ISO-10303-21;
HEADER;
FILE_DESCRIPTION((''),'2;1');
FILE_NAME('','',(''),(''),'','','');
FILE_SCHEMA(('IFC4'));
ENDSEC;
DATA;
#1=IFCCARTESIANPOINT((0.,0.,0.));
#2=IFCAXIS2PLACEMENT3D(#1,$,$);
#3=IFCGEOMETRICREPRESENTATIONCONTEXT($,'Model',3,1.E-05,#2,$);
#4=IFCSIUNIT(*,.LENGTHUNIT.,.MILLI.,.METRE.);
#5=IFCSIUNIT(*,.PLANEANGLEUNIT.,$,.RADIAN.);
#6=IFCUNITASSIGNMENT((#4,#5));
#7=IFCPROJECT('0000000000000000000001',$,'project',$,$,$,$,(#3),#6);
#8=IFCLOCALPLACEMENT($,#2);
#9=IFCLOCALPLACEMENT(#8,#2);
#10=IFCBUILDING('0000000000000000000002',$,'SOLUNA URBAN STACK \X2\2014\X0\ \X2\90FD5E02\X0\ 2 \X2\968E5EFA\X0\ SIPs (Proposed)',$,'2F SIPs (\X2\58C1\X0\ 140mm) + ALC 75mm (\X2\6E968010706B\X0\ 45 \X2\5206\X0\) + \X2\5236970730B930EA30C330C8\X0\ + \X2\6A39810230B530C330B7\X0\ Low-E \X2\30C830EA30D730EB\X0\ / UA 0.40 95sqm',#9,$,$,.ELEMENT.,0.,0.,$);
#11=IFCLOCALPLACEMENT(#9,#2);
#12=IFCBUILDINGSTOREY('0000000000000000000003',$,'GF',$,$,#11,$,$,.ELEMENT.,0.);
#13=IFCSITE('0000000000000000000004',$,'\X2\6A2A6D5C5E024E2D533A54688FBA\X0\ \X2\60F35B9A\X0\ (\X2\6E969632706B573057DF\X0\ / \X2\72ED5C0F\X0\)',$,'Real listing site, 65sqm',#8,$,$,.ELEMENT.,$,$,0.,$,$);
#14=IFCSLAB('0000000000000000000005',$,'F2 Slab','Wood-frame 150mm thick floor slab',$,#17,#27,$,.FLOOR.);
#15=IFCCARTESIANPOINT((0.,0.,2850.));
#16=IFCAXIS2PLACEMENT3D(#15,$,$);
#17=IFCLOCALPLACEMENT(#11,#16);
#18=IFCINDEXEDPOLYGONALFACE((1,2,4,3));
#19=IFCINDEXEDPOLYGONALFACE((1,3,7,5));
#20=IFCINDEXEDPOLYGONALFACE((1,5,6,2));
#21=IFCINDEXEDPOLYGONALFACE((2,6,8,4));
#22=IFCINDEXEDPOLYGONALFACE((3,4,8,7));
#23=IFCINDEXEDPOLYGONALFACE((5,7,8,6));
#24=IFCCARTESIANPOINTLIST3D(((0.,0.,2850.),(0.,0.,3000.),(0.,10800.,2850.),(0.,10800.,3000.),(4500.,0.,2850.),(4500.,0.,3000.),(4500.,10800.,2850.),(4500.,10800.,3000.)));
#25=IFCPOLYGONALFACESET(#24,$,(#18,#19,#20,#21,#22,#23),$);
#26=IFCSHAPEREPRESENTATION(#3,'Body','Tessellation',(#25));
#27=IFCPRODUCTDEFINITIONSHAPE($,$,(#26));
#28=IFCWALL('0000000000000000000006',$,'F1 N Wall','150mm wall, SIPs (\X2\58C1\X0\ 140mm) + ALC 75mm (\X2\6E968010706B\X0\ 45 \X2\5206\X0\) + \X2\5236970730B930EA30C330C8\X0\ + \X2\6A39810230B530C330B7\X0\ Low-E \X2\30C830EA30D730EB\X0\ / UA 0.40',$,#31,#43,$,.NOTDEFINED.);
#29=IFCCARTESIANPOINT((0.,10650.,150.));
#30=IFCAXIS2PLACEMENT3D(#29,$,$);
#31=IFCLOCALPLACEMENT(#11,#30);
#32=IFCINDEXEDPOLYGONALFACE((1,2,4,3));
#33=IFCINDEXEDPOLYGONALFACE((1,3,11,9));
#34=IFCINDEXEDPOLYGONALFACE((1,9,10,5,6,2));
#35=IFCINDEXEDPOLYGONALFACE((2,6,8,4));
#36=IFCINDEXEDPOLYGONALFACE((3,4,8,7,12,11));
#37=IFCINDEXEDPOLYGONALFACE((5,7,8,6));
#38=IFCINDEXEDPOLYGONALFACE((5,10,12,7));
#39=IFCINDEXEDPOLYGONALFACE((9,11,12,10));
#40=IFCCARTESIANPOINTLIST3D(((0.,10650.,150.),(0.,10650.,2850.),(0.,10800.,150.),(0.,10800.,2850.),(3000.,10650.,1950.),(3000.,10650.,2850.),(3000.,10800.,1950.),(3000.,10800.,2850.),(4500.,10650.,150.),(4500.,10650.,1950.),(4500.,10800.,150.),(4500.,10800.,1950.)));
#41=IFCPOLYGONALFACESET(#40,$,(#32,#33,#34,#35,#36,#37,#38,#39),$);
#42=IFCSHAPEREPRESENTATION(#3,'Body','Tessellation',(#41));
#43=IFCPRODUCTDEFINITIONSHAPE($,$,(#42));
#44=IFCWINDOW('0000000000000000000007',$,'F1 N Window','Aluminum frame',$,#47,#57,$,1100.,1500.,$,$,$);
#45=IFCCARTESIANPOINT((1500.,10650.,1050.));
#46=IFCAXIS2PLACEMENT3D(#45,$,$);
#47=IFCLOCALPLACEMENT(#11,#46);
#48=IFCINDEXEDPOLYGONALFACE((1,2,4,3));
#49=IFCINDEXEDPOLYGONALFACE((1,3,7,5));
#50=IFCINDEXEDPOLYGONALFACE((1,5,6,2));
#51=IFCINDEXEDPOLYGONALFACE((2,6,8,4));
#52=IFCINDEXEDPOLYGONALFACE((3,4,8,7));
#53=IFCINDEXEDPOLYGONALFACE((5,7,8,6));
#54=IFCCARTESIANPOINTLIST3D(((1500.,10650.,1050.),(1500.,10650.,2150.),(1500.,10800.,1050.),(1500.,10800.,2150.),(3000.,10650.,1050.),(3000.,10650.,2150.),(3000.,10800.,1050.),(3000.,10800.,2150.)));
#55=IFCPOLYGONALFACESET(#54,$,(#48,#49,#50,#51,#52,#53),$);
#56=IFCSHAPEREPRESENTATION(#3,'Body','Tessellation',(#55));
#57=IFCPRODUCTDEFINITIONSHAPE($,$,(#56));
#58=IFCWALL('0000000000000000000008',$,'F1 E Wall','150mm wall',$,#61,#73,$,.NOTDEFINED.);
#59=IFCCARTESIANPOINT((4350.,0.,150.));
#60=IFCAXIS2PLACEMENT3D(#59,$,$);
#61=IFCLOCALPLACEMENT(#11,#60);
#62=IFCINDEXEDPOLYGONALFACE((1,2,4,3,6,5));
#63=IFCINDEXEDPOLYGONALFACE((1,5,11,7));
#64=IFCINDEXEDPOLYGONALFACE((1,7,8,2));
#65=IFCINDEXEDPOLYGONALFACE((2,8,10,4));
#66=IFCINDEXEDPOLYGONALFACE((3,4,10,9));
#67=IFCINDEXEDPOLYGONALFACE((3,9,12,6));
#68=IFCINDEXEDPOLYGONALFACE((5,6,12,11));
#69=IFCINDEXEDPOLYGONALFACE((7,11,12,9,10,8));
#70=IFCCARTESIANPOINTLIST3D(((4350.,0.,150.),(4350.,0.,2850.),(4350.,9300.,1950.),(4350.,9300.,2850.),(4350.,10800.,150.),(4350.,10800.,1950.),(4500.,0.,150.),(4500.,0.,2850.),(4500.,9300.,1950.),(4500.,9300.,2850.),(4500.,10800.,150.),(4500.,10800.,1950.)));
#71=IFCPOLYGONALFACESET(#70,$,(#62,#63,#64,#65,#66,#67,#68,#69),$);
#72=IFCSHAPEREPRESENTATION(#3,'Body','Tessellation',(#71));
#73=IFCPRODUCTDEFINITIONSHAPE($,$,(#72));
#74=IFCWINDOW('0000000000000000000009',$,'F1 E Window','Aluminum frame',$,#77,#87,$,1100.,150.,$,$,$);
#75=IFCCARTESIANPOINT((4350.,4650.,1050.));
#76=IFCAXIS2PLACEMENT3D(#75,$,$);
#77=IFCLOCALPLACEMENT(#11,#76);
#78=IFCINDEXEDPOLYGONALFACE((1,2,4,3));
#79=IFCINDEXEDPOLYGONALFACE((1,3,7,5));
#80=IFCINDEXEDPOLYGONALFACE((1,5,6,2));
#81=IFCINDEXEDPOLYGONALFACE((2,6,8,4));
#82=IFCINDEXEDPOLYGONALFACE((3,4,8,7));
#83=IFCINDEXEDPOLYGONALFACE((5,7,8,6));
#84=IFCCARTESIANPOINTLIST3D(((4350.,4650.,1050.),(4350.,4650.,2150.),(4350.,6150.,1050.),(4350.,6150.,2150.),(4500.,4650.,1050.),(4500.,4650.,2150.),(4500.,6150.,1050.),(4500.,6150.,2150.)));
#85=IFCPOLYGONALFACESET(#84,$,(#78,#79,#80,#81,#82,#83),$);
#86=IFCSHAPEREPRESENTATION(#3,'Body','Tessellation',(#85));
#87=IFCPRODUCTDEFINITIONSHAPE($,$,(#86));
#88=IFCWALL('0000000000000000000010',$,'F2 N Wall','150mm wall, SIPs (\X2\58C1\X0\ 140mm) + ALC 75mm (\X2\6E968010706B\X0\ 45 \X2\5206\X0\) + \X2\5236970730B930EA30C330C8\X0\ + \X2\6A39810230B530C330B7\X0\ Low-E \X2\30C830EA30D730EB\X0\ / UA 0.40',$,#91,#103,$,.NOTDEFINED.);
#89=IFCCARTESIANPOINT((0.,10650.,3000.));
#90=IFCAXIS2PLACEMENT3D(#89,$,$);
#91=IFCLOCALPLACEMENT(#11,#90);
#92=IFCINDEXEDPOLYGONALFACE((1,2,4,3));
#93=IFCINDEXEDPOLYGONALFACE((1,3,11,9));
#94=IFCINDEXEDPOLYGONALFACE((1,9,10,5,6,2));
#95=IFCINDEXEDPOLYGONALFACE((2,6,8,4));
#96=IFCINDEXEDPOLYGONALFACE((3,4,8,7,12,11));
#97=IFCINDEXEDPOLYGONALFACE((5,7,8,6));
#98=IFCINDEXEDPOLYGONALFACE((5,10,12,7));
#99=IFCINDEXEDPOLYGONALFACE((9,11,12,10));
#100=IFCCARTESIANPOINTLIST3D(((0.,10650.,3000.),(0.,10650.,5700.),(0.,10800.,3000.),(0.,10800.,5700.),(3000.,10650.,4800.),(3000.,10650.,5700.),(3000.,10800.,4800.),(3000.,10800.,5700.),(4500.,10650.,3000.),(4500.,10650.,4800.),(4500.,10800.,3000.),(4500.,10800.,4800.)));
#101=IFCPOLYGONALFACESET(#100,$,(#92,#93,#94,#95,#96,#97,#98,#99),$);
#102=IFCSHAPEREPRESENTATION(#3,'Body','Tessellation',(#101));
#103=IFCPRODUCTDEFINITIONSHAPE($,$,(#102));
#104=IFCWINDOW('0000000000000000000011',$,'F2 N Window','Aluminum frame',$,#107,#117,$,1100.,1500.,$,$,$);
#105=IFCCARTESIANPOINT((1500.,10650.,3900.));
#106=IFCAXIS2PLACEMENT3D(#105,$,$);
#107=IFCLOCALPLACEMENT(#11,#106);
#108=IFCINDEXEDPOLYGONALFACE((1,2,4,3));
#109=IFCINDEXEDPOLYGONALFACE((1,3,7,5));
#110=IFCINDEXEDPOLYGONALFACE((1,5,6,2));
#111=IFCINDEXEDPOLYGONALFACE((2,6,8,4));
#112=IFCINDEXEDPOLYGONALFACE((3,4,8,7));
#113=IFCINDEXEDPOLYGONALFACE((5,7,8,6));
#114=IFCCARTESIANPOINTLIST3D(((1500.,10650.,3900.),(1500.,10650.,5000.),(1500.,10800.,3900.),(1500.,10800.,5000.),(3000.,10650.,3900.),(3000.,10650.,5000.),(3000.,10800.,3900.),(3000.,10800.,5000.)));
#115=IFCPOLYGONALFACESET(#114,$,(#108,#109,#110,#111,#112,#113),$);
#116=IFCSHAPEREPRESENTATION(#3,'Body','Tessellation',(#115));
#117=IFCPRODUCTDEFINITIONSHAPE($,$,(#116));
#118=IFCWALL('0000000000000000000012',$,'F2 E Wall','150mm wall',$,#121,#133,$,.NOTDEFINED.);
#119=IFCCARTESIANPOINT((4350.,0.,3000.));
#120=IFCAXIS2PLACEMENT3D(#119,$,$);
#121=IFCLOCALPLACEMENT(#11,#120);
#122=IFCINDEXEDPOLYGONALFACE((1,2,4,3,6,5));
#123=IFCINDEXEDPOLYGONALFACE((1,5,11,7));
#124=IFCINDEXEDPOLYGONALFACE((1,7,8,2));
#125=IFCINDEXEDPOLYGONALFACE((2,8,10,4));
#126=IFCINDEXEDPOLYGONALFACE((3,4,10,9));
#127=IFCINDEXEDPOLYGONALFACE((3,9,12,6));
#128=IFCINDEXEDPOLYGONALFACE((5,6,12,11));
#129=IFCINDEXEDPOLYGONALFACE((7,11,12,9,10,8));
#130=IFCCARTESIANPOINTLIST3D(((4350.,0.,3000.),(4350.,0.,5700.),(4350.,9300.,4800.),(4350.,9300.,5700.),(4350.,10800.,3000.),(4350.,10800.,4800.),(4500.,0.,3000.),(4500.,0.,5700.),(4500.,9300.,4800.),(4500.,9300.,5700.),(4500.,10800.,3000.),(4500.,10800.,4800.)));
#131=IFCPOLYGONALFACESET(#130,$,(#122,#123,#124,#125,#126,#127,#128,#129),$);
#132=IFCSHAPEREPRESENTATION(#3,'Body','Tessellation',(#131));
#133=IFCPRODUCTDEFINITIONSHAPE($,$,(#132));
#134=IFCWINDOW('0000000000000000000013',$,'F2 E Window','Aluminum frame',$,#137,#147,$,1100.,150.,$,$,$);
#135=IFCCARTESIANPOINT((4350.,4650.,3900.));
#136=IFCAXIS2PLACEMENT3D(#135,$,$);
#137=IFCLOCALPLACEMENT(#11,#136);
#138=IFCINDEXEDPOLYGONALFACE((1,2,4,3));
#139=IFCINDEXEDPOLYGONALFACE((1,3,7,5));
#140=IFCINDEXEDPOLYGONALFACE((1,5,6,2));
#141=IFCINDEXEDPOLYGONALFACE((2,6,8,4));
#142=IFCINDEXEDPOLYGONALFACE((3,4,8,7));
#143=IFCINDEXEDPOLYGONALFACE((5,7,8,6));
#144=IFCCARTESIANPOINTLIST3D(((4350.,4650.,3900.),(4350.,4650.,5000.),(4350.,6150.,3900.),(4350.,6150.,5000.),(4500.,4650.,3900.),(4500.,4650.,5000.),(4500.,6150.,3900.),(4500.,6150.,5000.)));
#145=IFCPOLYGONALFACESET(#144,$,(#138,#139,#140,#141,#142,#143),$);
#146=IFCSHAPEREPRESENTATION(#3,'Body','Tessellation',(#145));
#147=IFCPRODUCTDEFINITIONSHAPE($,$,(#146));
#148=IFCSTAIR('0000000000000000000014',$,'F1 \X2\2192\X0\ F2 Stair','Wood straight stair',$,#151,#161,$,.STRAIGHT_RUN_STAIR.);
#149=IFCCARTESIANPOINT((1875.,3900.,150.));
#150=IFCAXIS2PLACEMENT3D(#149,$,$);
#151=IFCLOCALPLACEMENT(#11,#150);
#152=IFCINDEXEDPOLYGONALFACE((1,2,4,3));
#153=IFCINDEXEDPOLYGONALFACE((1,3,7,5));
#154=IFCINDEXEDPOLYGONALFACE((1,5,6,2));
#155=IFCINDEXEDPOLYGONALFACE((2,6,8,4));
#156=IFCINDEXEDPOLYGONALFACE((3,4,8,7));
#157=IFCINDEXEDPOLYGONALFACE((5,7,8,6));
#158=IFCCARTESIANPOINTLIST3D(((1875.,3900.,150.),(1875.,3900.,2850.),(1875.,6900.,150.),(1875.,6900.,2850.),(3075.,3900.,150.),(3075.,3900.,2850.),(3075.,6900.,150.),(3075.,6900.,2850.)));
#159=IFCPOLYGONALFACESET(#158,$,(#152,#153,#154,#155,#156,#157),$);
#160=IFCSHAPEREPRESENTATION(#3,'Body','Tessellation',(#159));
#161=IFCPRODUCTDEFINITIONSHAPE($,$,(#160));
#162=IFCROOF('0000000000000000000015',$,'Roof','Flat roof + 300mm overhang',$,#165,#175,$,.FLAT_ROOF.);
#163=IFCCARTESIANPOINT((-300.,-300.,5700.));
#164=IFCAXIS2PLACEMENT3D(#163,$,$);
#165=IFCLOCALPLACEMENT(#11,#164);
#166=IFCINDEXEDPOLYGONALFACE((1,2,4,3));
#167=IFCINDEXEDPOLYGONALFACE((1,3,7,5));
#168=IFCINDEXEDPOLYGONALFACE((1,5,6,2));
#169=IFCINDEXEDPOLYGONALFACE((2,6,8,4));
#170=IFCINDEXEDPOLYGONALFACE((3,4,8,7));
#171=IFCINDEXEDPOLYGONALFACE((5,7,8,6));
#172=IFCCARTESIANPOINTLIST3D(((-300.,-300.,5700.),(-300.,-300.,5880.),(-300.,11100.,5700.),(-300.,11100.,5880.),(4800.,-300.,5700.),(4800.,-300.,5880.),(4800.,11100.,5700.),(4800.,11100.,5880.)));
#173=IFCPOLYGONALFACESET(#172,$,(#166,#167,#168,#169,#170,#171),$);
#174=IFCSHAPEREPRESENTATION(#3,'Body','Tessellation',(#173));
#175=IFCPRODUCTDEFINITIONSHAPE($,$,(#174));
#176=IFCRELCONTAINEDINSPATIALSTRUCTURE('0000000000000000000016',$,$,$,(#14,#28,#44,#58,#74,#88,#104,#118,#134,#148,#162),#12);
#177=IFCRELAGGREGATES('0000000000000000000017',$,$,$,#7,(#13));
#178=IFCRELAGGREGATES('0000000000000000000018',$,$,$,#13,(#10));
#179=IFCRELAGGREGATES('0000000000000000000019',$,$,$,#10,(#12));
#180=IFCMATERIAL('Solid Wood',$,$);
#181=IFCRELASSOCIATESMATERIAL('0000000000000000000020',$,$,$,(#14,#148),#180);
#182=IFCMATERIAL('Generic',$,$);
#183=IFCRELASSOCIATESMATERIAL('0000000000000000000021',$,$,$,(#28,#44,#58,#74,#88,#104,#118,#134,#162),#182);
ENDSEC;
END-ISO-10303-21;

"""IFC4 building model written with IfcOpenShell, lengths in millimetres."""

from ifc_helpers import new_model, si_unit, frame, frame_2d, origin, place, context, project, spatial, rectangle, extrude, material, element, fill, save


model = new_model("IFC4")

# Units and contexts
model_context = context("Model", 3, precision=1e-05, world=origin())
ifc_project = project(units=[si_unit("LENGTHUNIT", "METRE", prefix="MILLI"), si_unit("PLANEANGLEUNIT", "RADIAN")], contexts=[model_context])

# Site, building, storey
site_placement = place(None, origin())
site = spatial("IfcSite", under=ifc_project, at=site_placement, Name="横浜市中区周辺 想定 (準防火地域 / 狭小)", ObjectType="Real listing site, 65sqm", CompositionType="ELEMENT", RefElevation=0.0)
building_placement = place(site_placement, origin())
building = spatial("IfcBuilding", under=site, at=building_placement, Name="SOLUNA URBAN STACK — 都市 2 階建 SIPs (Proposed)", ObjectType="2F SIPs (壁 140mm) + ALC 75mm (準耐火 45 分) + 制震スリット + 樹脂サッシ Low-E トリプル / UA 0.40 95sqm", CompositionType="ELEMENT", ElevationOfRefHeight=0.0, ElevationOfTerrain=0.0)
storey_placement = place(building_placement, origin())
storey = spatial("IfcBuildingStorey", under=building, at=storey_placement, Name="GF", CompositionType="ELEMENT", Elevation=0.0)

# Slab
ifc_material_1 = material(Name="Solid Wood")
slab_1_placement = place(storey_placement, frame((0.0, 0.0, 2850.0)))
element("IfcSlab", 1, at=slab_1_placement, inside=storey, material=ifc_material_1, Name="F2 Slab", Description="Wood-frame 150mm thick floor slab", PredefinedType="FLOOR", context=model_context, shape_type="SweptSolid", body=[
    extrude(rectangle(XDim=4500.0, YDim=10800.0, at=frame_2d((2250.0, 5400.0))), frame((0.0, 0.0, 2850.0)), (0.0, 0.0, 1.0), 150.0),
])

# Wall, opening, window
ifc_material_2 = material(Name="Generic")
wall_1_placement = place(storey_placement, frame((0.0, 10650.0, 150.0)))
wall_1 = element("IfcWall", 2, at=wall_1_placement, inside=storey, material=ifc_material_2, Name="F1 N Wall", Description="150mm wall, SIPs (壁 140mm) + ALC 75mm (準耐火 45 分) + 制震スリット + 樹脂サッシ Low-E トリプル / UA 0.40", PredefinedType="NOTDEFINED", context=model_context, shape_type="SweptSolid", body=[
    extrude(rectangle(XDim=4500.0, YDim=150.0, at=frame_2d((2250.0, 75.0))), frame((0.0, 10650.0, 150.0)), (0.0, 0.0, 1.0), 2700.0),
])
opening_1_placement = place(storey_placement, frame((1500.0, 10650.0, 1050.0)))
opening_1 = element("IfcOpeningElement", 3, at=opening_1_placement, cuts=wall_1, PredefinedType="NOTDEFINED", context=model_context, shape_type="SweptSolid", body=[
    extrude(rectangle(XDim=1500.0, YDim=150.0, at=frame_2d((750.0, 75.0))), frame((1500.0, 10650.0, 1050.0)), (0.0, 0.0, 1.0), 1100.0),
])
window_1_placement = place(storey_placement, frame((1500.0, 10650.0, 1050.0)))
window_1 = element("IfcWindow", 4, at=window_1_placement, inside=storey, material=ifc_material_2, Name="F1 N Window", Description="Aluminum frame", OverallHeight=1100.0, OverallWidth=1500.0, context=model_context, shape_type="SweptSolid", body=[
    extrude(rectangle(XDim=1500.0, YDim=150.0, at=frame_2d((750.0, 75.0))), frame((1500.0, 10650.0, 1050.0)), (0.0, 0.0, 1.0), 1100.0),
])
fill(opening_1, window_1)

# Walls, openings, windows
wall_2_placement = place(storey_placement, frame((4350.0, 0.0, 150.0)))
wall_2 = element("IfcWall", 5, at=wall_2_placement, inside=storey, material=ifc_material_2, Name="F1 E Wall", Description="150mm wall", PredefinedType="NOTDEFINED", context=model_context, shape_type="SweptSolid", body=[
    extrude(rectangle(XDim=150.0, YDim=10800.0, at=frame_2d((75.0, 5400.0))), frame((4350.0, 0.0, 150.0)), (0.0, 0.0, 1.0), 2700.0),
])
opening_2_placement = place(storey_placement, frame((4350.0, 4650.0, 1050.0)))
opening_2 = element("IfcOpeningElement", 6, at=opening_2_placement, cuts=wall_2, PredefinedType="NOTDEFINED", context=model_context, shape_type="SweptSolid", body=[
    extrude(rectangle(XDim=150.0, YDim=1500.0, at=frame_2d((75.0, 750.0))), frame((4350.0, 4650.0, 1050.0)), (0.0, 0.0, 1.0), 1100.0),
])
window_2_placement = place(storey_placement, frame((4350.0, 4650.0, 1050.0)))
window_2 = element("IfcWindow", 7, at=window_2_placement, inside=storey, material=ifc_material_2, Name="F1 E Window", Description="Aluminum frame", OverallHeight=1100.0, OverallWidth=150.0, context=model_context, shape_type="SweptSolid", body=[
    extrude(rectangle(XDim=150.0, YDim=1500.0, at=frame_2d((75.0, 750.0))), frame((4350.0, 4650.0, 1050.0)), (0.0, 0.0, 1.0), 1100.0),
])
fill(opening_2, window_2)
wall_3_placement = place(storey_placement, frame((0.0, 10650.0, 3000.0)))
wall_3 = element("IfcWall", 8, at=wall_3_placement, inside=storey, material=ifc_material_2, Name="F2 N Wall", Description="150mm wall, SIPs (壁 140mm) + ALC 75mm (準耐火 45 分) + 制震スリット + 樹脂サッシ Low-E トリプル / UA 0.40", PredefinedType="NOTDEFINED", context=model_context, shape_type="SweptSolid", body=[
    extrude(rectangle(XDim=4500.0, YDim=150.0, at=frame_2d((2250.0, 75.0))), frame((0.0, 10650.0, 3000.0)), (0.0, 0.0, 1.0), 2700.0),
])
opening_3_placement = place(storey_placement, frame((1500.0, 10650.0, 3900.0)))
opening_3 = element("IfcOpeningElement", 9, at=opening_3_placement, cuts=wall_3, PredefinedType="NOTDEFINED", context=model_context, shape_type="SweptSolid", body=[
    extrude(rectangle(XDim=1500.0, YDim=150.0, at=frame_2d((750.0, 75.0))), frame((1500.0, 10650.0, 3900.0)), (0.0, 0.0, 1.0), 1100.0),
])
window_3_placement = place(storey_placement, frame((1500.0, 10650.0, 3900.0)))
window_3 = element("IfcWindow", 10, at=window_3_placement, inside=storey, material=ifc_material_2, Name="F2 N Window", Description="Aluminum frame", OverallHeight=1100.0, OverallWidth=1500.0, context=model_context, shape_type="SweptSolid", body=[
    extrude(rectangle(XDim=1500.0, YDim=150.0, at=frame_2d((750.0, 75.0))), frame((1500.0, 10650.0, 3900.0)), (0.0, 0.0, 1.0), 1100.0),
])
fill(opening_3, window_3)
wall_4_placement = place(storey_placement, frame((4350.0, 0.0, 3000.0)))
wall_4 = element("IfcWall", 11, at=wall_4_placement, inside=storey, material=ifc_material_2, Name="F2 E Wall", Description="150mm wall", PredefinedType="NOTDEFINED", context=model_context, shape_type="SweptSolid", body=[
    extrude(rectangle(XDim=150.0, YDim=10800.0, at=frame_2d((75.0, 5400.0))), frame((4350.0, 0.0, 3000.0)), (0.0, 0.0, 1.0), 2700.0),
])
opening_4_placement = place(storey_placement, frame((4350.0, 4650.0, 3900.0)))
opening_4 = element("IfcOpeningElement", 12, at=opening_4_placement, cuts=wall_4, PredefinedType="NOTDEFINED", context=model_context, shape_type="SweptSolid", body=[
    extrude(rectangle(XDim=150.0, YDim=1500.0, at=frame_2d((75.0, 750.0))), frame((4350.0, 4650.0, 3900.0)), (0.0, 0.0, 1.0), 1100.0),
])
window_4_placement = place(storey_placement, frame((4350.0, 4650.0, 3900.0)))
window_4 = element("IfcWindow", 13, at=window_4_placement, inside=storey, material=ifc_material_2, Name="F2 E Window", Description="Aluminum frame", OverallHeight=1100.0, OverallWidth=150.0, context=model_context, shape_type="SweptSolid", body=[
    extrude(rectangle(XDim=150.0, YDim=1500.0, at=frame_2d((75.0, 750.0))), frame((4350.0, 4650.0, 3900.0)), (0.0, 0.0, 1.0), 1100.0),
])
fill(opening_4, window_4)

# Stair
stair_placement = place(storey_placement, frame((1875.0, 3900.0, 150.0)))
element("IfcStair", 14, at=stair_placement, inside=storey, material=ifc_material_1, Name="F1 → F2 Stair", Description="Wood straight stair", PredefinedType="STRAIGHT_RUN_STAIR", context=model_context, shape_type="SweptSolid", body=[
    extrude(rectangle(XDim=1200.0, YDim=3000.0, at=frame_2d((600.0, 1500.0))), frame((1875.0, 3900.0, 150.0)), (0.0, 0.0, 1.0), 2700.0),
])

# Roof
roof_placement = place(storey_placement, frame((-300.0, -300.0, 5700.0)))
element("IfcRoof", 15, at=roof_placement, inside=storey, material=ifc_material_2, Name="Roof", Description="Flat roof + 300mm overhang", PredefinedType="FLAT_ROOF", context=model_context, shape_type="SweptSolid", body=[
    extrude(rectangle(XDim=5100.0, YDim=11400.0, at=frame_2d((2550.0, 5700.0))), frame((-300.0, -300.0, 5700.0)), (0.0, 0.0, 1.0), 180.0),
])

save(model, "model.ifc")
